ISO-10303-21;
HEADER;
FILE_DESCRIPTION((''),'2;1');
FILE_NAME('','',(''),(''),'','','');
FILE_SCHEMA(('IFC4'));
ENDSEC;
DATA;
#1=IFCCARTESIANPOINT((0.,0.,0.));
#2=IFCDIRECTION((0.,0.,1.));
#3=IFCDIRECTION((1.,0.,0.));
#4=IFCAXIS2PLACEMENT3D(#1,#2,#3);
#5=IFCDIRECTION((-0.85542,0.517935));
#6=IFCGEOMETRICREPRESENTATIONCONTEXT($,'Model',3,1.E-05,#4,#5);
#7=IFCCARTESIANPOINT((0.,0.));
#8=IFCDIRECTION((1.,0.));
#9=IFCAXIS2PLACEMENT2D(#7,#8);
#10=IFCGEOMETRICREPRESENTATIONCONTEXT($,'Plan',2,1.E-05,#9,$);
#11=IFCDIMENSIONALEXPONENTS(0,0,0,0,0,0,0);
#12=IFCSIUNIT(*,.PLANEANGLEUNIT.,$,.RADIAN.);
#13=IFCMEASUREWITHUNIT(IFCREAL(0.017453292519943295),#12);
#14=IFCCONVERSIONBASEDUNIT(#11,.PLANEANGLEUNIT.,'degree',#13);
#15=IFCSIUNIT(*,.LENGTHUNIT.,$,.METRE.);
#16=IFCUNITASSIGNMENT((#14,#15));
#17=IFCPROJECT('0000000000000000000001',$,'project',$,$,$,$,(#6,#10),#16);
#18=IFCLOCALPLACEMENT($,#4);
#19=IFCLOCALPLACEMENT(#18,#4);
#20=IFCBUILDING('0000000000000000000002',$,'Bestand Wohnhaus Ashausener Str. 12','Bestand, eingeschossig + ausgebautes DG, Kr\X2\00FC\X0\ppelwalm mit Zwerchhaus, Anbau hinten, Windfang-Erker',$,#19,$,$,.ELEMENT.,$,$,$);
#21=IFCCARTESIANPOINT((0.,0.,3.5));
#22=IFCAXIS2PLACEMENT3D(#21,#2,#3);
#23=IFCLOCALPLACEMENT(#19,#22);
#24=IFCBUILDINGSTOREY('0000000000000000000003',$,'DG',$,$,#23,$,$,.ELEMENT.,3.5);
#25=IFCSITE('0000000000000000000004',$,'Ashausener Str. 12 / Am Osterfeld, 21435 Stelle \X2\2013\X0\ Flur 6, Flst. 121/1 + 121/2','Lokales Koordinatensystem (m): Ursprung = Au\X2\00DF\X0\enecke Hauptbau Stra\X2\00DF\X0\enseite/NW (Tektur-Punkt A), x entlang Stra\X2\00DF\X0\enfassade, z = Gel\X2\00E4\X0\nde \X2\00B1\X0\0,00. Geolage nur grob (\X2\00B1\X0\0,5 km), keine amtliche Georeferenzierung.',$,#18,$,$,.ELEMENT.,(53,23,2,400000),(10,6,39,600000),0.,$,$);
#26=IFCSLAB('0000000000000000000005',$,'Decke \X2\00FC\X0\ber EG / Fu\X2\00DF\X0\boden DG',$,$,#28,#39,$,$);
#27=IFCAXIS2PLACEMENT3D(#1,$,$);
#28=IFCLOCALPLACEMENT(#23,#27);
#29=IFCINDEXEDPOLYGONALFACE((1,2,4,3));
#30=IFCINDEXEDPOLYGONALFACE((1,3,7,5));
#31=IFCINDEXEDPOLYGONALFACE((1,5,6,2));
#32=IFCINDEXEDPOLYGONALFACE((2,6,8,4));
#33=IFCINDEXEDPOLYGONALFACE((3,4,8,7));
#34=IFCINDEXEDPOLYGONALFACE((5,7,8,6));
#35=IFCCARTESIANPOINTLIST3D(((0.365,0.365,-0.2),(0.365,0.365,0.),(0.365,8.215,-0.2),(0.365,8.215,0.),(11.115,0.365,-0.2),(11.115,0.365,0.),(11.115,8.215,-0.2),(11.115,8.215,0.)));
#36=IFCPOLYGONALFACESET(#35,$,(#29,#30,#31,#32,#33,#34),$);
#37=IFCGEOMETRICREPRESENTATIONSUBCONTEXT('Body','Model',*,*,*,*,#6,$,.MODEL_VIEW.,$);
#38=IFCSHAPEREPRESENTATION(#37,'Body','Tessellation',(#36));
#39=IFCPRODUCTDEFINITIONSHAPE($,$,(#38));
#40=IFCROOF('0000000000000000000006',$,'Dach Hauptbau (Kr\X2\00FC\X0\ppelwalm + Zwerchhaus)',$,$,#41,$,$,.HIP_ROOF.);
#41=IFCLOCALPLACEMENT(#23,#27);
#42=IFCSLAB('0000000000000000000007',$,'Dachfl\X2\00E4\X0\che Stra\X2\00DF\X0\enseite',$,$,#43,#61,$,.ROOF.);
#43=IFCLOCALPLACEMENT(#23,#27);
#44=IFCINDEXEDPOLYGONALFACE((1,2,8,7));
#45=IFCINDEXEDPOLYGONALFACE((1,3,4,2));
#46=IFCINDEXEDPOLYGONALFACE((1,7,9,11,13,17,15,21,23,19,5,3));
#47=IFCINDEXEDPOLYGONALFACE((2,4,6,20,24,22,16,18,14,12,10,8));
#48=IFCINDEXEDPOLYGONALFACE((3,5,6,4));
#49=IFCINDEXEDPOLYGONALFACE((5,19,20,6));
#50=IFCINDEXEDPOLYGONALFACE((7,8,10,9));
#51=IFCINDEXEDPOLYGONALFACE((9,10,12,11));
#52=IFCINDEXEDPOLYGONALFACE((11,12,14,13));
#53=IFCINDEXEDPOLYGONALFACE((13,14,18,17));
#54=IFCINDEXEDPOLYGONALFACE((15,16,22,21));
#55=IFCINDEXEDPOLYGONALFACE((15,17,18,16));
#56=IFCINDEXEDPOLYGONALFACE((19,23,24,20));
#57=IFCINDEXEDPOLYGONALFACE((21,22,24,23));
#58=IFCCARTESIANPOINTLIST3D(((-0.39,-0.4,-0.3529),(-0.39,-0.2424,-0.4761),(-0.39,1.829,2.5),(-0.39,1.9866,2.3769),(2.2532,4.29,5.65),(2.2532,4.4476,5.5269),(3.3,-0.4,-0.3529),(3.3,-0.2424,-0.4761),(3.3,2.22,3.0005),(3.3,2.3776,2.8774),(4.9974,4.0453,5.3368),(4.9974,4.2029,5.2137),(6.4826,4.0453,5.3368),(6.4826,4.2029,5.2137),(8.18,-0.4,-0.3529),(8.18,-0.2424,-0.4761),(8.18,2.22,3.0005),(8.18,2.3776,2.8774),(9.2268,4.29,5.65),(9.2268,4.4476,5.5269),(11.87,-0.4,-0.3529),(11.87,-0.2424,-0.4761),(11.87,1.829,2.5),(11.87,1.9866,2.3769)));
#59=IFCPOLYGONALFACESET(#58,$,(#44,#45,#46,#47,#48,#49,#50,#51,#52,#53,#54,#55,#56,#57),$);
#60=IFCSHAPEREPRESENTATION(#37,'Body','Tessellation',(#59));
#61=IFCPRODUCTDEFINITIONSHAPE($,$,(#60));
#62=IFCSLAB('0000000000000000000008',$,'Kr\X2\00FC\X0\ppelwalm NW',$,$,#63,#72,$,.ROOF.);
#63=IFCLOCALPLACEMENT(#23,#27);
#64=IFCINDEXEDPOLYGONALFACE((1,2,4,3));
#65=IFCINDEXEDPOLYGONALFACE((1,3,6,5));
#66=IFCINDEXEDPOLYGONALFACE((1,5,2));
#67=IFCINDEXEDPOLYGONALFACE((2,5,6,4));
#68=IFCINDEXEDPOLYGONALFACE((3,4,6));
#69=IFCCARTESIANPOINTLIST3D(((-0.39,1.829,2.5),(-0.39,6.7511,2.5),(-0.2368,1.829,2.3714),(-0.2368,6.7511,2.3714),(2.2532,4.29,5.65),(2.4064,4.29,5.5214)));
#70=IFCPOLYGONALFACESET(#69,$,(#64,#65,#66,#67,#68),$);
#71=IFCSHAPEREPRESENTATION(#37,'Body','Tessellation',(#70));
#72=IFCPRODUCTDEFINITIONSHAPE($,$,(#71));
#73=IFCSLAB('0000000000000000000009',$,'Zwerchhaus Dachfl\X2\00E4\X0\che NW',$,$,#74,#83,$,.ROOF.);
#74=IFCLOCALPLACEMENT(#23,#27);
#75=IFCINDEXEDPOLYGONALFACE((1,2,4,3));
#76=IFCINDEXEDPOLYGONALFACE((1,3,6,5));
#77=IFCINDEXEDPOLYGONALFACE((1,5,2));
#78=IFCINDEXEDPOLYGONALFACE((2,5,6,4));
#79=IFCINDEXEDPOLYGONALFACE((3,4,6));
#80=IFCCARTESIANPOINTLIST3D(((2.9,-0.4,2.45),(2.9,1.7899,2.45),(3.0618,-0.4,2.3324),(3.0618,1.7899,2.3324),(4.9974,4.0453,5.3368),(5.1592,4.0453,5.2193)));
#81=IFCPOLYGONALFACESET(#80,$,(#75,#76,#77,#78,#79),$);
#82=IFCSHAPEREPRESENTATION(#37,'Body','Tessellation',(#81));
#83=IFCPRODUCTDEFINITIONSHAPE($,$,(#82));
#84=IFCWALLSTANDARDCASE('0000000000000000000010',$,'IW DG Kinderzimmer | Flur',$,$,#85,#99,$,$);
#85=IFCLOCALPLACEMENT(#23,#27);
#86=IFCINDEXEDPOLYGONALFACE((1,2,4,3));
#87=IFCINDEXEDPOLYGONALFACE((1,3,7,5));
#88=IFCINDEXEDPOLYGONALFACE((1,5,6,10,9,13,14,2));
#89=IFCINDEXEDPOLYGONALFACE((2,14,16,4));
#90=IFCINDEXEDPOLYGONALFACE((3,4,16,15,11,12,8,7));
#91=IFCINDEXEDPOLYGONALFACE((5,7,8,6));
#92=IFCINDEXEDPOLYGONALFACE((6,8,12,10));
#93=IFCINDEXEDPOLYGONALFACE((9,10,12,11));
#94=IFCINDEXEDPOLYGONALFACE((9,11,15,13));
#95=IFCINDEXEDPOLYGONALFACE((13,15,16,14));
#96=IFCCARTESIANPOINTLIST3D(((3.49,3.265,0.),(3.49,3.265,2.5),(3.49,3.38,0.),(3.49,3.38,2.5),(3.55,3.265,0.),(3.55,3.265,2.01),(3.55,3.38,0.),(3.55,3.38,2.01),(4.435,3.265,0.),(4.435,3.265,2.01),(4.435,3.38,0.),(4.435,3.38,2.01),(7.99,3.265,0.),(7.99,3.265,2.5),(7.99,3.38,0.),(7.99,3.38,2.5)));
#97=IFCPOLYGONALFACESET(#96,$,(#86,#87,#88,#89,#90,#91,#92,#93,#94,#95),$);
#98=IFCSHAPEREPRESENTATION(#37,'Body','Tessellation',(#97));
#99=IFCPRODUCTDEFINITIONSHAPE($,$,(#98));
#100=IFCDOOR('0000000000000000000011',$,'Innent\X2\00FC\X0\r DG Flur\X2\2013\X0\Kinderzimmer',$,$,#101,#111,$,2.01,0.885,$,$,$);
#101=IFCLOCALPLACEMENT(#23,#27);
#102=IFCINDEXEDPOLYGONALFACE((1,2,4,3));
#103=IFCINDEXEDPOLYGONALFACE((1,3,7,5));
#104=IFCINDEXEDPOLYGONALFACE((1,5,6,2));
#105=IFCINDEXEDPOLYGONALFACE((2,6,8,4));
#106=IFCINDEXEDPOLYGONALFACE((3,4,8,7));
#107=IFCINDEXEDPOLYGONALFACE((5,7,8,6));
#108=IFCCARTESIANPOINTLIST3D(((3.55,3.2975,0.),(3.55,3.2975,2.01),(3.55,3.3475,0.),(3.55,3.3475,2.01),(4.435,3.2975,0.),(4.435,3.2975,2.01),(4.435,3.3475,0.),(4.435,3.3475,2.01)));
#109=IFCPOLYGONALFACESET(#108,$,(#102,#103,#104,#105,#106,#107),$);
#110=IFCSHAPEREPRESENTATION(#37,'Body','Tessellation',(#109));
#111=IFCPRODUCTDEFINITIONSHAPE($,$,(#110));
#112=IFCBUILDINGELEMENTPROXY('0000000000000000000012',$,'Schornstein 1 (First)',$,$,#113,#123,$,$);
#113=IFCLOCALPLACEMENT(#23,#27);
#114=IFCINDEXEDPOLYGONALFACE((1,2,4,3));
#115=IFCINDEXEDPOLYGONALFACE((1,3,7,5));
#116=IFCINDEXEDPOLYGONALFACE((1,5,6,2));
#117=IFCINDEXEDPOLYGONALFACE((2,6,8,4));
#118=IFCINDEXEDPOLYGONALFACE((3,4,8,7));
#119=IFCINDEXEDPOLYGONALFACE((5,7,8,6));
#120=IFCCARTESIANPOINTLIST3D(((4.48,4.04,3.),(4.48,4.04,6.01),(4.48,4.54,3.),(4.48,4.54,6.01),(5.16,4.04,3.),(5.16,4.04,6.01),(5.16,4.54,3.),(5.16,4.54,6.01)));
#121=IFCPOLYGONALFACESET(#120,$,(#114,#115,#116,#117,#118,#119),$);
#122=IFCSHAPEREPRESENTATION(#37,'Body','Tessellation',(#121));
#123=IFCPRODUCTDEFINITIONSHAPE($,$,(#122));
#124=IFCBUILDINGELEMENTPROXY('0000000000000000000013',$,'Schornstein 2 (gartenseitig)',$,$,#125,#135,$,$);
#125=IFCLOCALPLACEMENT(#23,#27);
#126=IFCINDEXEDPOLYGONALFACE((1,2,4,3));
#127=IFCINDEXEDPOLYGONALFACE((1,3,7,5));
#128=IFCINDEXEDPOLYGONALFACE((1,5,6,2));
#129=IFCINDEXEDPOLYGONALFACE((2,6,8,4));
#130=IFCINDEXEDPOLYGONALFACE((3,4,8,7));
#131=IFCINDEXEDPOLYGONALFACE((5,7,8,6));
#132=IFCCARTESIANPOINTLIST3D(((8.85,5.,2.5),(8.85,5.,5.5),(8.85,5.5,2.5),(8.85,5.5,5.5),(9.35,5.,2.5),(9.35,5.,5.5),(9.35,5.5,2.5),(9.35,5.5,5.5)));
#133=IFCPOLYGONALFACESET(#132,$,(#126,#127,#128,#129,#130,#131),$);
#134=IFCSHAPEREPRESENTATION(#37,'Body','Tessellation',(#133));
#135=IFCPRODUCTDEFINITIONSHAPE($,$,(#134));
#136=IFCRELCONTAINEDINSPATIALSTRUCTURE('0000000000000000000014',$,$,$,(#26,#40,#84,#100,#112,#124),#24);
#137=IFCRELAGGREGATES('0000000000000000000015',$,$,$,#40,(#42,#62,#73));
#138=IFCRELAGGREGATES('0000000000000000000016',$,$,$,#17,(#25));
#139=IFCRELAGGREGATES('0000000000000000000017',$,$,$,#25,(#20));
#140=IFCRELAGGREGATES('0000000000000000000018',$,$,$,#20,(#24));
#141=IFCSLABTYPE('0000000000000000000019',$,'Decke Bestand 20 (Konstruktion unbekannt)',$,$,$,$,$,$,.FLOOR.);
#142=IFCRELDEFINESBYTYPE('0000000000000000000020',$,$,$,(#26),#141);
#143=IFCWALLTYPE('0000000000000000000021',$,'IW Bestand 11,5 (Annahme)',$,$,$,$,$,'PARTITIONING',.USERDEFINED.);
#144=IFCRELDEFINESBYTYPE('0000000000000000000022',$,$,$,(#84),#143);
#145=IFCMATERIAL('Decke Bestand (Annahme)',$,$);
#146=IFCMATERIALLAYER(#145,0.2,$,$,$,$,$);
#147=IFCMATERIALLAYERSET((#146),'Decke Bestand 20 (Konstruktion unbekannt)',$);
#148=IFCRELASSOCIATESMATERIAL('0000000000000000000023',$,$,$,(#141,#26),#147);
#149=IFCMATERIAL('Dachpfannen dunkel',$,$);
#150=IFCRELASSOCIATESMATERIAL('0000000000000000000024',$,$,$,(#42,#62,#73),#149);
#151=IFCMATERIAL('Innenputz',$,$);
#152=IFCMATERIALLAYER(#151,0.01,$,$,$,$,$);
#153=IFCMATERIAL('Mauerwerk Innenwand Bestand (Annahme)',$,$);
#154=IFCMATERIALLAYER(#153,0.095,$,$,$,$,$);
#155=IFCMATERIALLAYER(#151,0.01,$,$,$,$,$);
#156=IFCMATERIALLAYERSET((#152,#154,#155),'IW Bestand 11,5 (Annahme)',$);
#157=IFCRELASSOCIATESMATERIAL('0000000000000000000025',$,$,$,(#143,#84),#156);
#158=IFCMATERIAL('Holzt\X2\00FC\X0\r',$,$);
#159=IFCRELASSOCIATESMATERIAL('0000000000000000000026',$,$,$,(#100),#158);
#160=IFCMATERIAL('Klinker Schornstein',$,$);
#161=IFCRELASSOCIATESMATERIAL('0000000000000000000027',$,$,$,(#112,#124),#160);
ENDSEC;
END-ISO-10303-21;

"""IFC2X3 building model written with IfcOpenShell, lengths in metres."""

from ifc_helpers import new_model, entity, si_unit, converted_unit, direction, frame, origin_with_axes, origin_2d_with_axis, place, context, subcontext, project, spatial, polyline, outline, extrude, material, layer, layer_set, layer_usage, type_object, element, fill, aggregate, save


model = new_model("IFC2X3")

# Units and contexts
model_context = context("Model", 3, precision=1e-05, world=origin_with_axes(), true_north=direction((-0.85542, 0.517935)))
plan_context = context("Plan", 2, precision=1e-05, world=origin_2d_with_axis())
body_context = subcontext(model_context, "Body", "Model", "MODEL_VIEW")
ifc_project = project(units=[converted_unit("PLANEANGLEUNIT", "degree", entity("IfcReal", 0.017453292519943295), si_unit("PLANEANGLEUNIT", "RADIAN"), dimensions=[0, 0, 0, 0, 0, 0, 0]), si_unit("LENGTHUNIT", "METRE")], contexts=[model_context, plan_context])

# Site, building, storey
site_placement = place(None, origin_with_axes())
site = spatial("IfcSite", under=ifc_project, at=site_placement, Name="Ashausener Str. 12 / Am Osterfeld, 21435 Stelle – Flur 6, Flst. 121/1 + 121/2", Description="Lokales Koordinatensystem (m): Ursprung = Außenecke Hauptbau Straßenseite/NW (Tektur-Punkt A), x entlang Straßenfassade, z = Gelände ±0,00. Geolage nur grob (±0,5 km), keine amtliche Georeferenzierung.", CompositionType="ELEMENT", RefLatitude=(53, 23, 2, 400000), RefLongitude=(10, 6, 39, 600000), RefElevation=0.0)
building_placement = place(site_placement, origin_with_axes())
building = spatial("IfcBuilding", under=site, at=building_placement, Name="Bestand Wohnhaus Ashausener Str. 12", Description="Bestand, eingeschossig + ausgebautes DG, Krüppelwalm mit Zwerchhaus, Anbau hinten, Windfang-Erker", CompositionType="ELEMENT")
storey_placement = place(building_placement, frame((0.0, 0.0, 3.5), z_axis=(0.0, 0.0, 1.0), x_axis=(1.0, 0.0, 0.0)))
storey = spatial("IfcBuildingStorey", under=building, at=storey_placement, Name="DG", CompositionType="ELEMENT", Elevation=3.5)

# Slab
ifc_material_1 = material(Name="Decke Bestand (Annahme)")
ifc_layer_1 = layer(ifc_material_1, 0.2)
ifc_layer_set_1 = layer_set([ifc_layer_1], Name="Decke Bestand 20 (Konstruktion unbekannt)")
ifc_layer_usage_1 = layer_usage(ifc_layer_set_1, "AXIS3", "POSITIVE", 0.0)
slab_type = type_object("IfcSlabType", Name="Decke Bestand 20 (Konstruktion unbekannt)", PredefinedType="FLOOR", material=ifc_layer_set_1)
slab_1_placement = place(storey_placement, frame((0.0, 0.0, -3.5), z_axis=(0.0, 0.0, 1.0), x_axis=(1.0, 0.0, 0.0)))
element("IfcSlab", 1, at=slab_1_placement, inside=storey, type_object=slab_type, material=ifc_layer_usage_1, Name="Decke über EG / Fußboden DG", context=body_context, shape_type="SweptSolid", body=[
    extrude(outline(polyline([(0.365, 0.365), (11.115, 0.365), (11.115, 8.215), (0.365, 8.215), (0.365, 0.365)])), frame((0.0, 0.0, 3.3)), (0.0, 0.0, 1.0), 0.2),
])

# Roof, slabs
roof_placement = place(storey_placement, frame((0.0, 0.0, -3.5), z_axis=(0.0, 0.0, 1.0), x_axis=(1.0, 0.0, 0.0)))
roof = element("IfcRoof", 2, at=roof_placement, inside=storey, Name="Dach Hauptbau (Krüppelwalm + Zwerchhaus)", ShapeType="HIP_ROOF")
ifc_material_2 = material(Name="Dachpfannen dunkel")
slab_2_placement = place(roof_placement, origin_with_axes())
slab_2 = element("IfcSlab", 3, at=slab_2_placement, material=ifc_material_2, Name="Dachfläche Straßenseite", PredefinedType="ROOF", context=body_context, shape_type="SweptSolid", body=[
    extrude(outline(polyline([(0.0, 0.0), (3.69, 0.0), (3.69, 4.2556), (5.3874, 7.2204), (6.8726, 7.2204), (8.57, 4.2556), (8.57, 0.0), (12.26, 0.0), (12.26, 3.6204), (9.6168, 7.6178), (2.6432, 7.6178), (0.0, 3.6204), (0.0, 0.0)])), frame((-0.39, -0.4, 3.1471), z_axis=(0.0, -0.788011, 0.615661), x_axis=(1.0, 0.0, 0.0)), (0.0, 0.0, -1.0), 0.2),
])
slab_3_placement = place(roof_placement, origin_with_axes())
slab_3 = element("IfcSlab", 4, at=slab_3_placement, material=ifc_material_2, Name="Krüppelwalm NW", PredefinedType="ROOF", context=body_context, shape_type="SweptSolid", body=[
    extrude(outline(polyline([(0.0, 0.0), (4.7922, 0.0), (2.5277, 4.2235), (0.0, 0.0)])), frame((-0.39, 1.829, 6.0), z_axis=(-0.766045, 0.0, 0.642787), x_axis=(0.55155, 0.513549, 0.657313)), (0.0, 0.0, -1.0), 0.2),
])
slab_4_placement = place(roof_placement, origin_with_axes())
slab_4 = element("IfcSlab", 5, at=slab_4_placement, material=ifc_material_2, Name="Zwerchhaus Dachfläche NW", PredefinedType="ROOF", context=body_context, shape_type="SweptSolid", body=[
    extrude(outline(polyline([(0.0, 0.0), (5.7003, 0.0), (1.7078, 1.3708), (0.0, 0.0)])), frame((2.9, -0.4, 5.95), z_axis=(-0.809018, 0.0, 0.587784), x_axis=(0.367944, 0.779836, 0.506432)), (0.0, 0.0, -1.0), 0.2),
])
aggregate(roof, [slab_2, slab_3, slab_4])

# Wall, opening, door
ifc_material_3 = material(Name="Innenputz")
ifc_layer_2 = layer(ifc_material_3, 0.01)
ifc_material_4 = material(Name="Mauerwerk Innenwand Bestand (Annahme)")
ifc_layer_3 = layer(ifc_material_4, 0.095)
ifc_layer_4 = layer(ifc_material_3, 0.01)
ifc_layer_set_2 = layer_set([ifc_layer_2, ifc_layer_3, ifc_layer_4], Name="IW Bestand 11,5 (Annahme)")
ifc_layer_usage_2 = layer_usage(ifc_layer_set_2, "AXIS2", "POSITIVE", 0.0)
wall_type_1 = type_object("IfcWallType", Name="IW Bestand 11,5 (Annahme)", ElementType="PARTITIONING", PredefinedType="USERDEFINED", material=ifc_layer_set_2)
wall_1_placement = place(storey_placement, frame((3.49, 3.265, 0.0), z_axis=(0.0, 0.0, 1.0), x_axis=(1.0, 0.0, 0.0)))
wall_1 = element("IfcWallStandardCase", 6, at=wall_1_placement, inside=storey, type_object=wall_type_1, material=ifc_layer_usage_2, Name="IW DG Kinderzimmer | Flur", context=body_context, shape_type="SweptSolid", body=[
    extrude(outline(polyline([(0.0, 0.0), (0.0, 0.115), (4.5, 0.115), (4.5, 0.0), (0.0, 0.0)])), origin_with_axes(), (0.0, 0.0, 1.0), 2.5),
])
opening_1_placement = place(wall_1_placement, frame((0.06, -0.1, 0.0), z_axis=(0.0, 0.0, 1.0), x_axis=(1.0, 0.0, 0.0)))
opening_1 = element("IfcOpeningElement", 7, at=opening_1_placement, cuts=wall_1, context=body_context, shape_type="SweptSolid", body=[
    extrude(outline(polyline([(0.0, 0.0), (0.0, 0.315), (0.885, 0.315), (0.885, 0.0), (0.0, 0.0)])), origin_with_axes(), (0.0, 0.0, 1.0), 2.01),
])
ifc_material_5 = material(Name="Holztür")
door_1_placement = place(storey_placement, frame((3.55, 3.2975, 0.0), z_axis=(0.0, 0.0, 1.0), x_axis=(1.0, 0.0, 0.0)))
door_1 = element("IfcDoor", 8, at=door_1_placement, inside=storey, material=ifc_material_5, Name="Innentür DG Flur–Kinderzimmer", OverallHeight=2.01, OverallWidth=0.885, context=body_context, shape_type="SweptSolid", body=[
    extrude(outline(polyline([(0.0, 0.0), (0.0, 0.05), (0.885, 0.05), (0.885, 0.0), (0.0, 0.0)])), origin_with_axes(), (0.0, 0.0, 1.0), 2.01),
])
fill(opening_1, door_1)

# Building element proxies
ifc_material_6 = material(Name="Klinker Schornstein")
proxy_1_placement = place(storey_placement, frame((0.0, 0.0, -3.5), z_axis=(0.0, 0.0, 1.0), x_axis=(1.0, 0.0, 0.0)))
element("IfcBuildingElementProxy", 9, at=proxy_1_placement, inside=storey, material=ifc_material_6, Name="Schornstein 1 (First)", context=body_context, shape_type="SweptSolid", body=[
    extrude(outline(polyline([(4.48, 4.04), (5.16, 4.04), (5.16, 4.54), (4.48, 4.54), (4.48, 4.04)])), frame((0.0, 0.0, 6.5)), (0.0, 0.0, 1.0), 3.01),
])
proxy_2_placement = place(storey_placement, frame((0.0, 0.0, -3.5), z_axis=(0.0, 0.0, 1.0), x_axis=(1.0, 0.0, 0.0)))
element("IfcBuildingElementProxy", 10, at=proxy_2_placement, inside=storey, material=ifc_material_6, Name="Schornstein 2 (gartenseitig)", context=body_context, shape_type="SweptSolid", body=[
    extrude(outline(polyline([(8.85, 5.0), (9.35, 5.0), (9.35, 5.5), (8.85, 5.5), (8.85, 5.0)])), frame((0.0, 0.0, 6.0)), (0.0, 0.0, 1.0), 3.0),
])

save(model, "model.ifc")
